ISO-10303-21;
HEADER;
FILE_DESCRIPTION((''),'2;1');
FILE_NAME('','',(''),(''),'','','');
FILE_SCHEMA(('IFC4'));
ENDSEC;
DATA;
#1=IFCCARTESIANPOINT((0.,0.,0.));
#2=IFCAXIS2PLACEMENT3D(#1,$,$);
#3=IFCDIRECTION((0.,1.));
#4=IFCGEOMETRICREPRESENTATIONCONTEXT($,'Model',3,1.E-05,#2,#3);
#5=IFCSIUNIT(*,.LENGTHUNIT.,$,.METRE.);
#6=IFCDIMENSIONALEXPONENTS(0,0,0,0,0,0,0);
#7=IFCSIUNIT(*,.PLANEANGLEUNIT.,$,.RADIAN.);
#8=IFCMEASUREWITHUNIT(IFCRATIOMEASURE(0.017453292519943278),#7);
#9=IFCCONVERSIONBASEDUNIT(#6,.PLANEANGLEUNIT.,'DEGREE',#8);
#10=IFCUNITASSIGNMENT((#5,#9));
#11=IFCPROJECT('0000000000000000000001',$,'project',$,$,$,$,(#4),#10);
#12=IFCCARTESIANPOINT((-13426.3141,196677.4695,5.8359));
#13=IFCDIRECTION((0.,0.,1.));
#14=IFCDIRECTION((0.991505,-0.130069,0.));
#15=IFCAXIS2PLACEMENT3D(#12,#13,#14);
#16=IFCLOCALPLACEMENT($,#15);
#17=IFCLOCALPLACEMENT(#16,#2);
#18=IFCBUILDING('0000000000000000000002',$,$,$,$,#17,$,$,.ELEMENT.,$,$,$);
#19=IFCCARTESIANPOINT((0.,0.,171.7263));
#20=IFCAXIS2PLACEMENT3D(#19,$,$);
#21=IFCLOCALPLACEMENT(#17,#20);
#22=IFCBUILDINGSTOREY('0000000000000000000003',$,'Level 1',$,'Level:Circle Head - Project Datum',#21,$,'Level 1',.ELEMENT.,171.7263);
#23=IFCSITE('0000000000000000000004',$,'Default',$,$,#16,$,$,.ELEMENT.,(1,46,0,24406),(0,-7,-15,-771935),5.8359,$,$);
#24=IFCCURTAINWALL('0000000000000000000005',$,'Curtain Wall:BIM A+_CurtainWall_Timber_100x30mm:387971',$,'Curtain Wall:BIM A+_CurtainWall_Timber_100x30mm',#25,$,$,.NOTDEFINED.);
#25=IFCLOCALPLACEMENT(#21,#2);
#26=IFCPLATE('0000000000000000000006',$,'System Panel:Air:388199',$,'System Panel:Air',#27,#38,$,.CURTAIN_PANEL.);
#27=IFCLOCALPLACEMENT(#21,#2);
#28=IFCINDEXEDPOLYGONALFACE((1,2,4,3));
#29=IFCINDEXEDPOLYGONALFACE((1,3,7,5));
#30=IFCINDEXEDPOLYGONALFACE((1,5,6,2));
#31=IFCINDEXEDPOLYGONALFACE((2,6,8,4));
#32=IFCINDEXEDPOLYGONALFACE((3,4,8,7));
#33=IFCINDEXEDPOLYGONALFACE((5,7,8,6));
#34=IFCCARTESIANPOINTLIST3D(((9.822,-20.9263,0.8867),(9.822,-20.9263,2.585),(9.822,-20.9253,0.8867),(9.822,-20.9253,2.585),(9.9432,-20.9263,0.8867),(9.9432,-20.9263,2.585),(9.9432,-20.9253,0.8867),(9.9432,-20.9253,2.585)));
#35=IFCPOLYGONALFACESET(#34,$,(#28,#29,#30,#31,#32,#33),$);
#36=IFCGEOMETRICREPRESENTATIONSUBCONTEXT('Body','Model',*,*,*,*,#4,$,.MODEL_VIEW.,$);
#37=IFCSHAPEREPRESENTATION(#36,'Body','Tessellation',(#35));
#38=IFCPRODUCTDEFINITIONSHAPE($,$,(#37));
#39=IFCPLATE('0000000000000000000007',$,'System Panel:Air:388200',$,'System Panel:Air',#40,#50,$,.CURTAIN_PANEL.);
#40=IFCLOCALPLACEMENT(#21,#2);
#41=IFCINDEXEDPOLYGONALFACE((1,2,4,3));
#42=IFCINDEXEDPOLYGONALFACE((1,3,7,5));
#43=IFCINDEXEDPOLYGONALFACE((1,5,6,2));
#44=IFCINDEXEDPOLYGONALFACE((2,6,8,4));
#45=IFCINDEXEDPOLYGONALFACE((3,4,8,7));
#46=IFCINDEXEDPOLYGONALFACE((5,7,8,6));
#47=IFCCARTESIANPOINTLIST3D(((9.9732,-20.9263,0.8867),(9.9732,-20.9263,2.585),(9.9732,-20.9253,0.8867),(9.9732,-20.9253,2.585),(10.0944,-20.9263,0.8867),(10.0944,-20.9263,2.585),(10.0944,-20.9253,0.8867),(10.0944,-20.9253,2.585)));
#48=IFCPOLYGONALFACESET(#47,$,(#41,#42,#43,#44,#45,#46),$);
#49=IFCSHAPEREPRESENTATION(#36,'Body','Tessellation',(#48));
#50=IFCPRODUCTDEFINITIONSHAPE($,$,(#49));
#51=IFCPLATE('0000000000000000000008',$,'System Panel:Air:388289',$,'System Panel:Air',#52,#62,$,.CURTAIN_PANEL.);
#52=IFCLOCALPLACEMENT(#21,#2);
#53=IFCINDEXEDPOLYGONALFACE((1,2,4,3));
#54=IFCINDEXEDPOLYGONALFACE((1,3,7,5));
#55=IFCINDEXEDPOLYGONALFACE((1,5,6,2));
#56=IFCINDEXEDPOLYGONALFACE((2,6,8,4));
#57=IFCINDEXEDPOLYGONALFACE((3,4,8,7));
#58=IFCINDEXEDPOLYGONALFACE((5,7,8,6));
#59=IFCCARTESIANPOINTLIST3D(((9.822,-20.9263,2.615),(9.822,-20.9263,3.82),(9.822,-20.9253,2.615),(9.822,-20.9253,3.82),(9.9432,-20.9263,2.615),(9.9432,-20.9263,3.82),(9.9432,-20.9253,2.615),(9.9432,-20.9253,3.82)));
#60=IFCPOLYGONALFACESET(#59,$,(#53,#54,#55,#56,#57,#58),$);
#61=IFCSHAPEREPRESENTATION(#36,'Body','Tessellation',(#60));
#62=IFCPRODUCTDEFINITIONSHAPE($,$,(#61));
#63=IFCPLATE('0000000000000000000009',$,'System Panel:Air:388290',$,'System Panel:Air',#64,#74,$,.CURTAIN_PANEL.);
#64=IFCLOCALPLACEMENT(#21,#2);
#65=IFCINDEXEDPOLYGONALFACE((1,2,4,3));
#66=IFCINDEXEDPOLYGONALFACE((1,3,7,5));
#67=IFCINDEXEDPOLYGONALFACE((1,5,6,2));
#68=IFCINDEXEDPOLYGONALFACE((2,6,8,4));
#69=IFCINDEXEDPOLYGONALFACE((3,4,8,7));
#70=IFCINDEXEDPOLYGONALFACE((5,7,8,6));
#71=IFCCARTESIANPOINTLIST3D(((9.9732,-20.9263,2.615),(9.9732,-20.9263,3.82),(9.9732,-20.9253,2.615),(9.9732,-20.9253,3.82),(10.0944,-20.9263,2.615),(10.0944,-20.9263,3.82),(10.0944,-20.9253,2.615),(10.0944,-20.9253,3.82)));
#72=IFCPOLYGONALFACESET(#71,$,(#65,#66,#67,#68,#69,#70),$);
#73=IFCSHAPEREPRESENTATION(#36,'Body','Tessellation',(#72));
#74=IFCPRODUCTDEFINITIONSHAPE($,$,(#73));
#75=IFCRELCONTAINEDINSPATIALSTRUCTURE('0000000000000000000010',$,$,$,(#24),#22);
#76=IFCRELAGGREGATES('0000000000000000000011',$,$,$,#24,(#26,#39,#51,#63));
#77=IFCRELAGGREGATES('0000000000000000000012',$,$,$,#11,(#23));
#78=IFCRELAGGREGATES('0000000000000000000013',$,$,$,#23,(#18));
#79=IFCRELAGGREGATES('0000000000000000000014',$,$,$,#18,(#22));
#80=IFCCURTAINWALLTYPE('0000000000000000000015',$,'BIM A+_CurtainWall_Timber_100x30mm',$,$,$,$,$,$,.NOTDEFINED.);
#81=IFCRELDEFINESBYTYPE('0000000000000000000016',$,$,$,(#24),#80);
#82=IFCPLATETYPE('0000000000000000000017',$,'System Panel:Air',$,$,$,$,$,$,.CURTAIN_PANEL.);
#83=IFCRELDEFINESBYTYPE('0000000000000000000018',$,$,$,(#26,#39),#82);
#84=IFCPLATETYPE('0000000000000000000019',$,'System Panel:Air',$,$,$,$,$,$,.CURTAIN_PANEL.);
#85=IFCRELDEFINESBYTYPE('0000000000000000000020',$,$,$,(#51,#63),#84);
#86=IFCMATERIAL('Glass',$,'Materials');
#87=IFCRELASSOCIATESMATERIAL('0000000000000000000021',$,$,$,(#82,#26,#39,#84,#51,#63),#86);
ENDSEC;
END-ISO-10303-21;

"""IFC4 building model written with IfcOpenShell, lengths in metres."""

from ifc_helpers import new_model, entity, si_unit, converted_unit, direction, frame, origin, place, context, subcontext, project, spatial, indexed_curve, outline, extrude, source, transform, mapped, material, type_object, type_shapes, element, aggregate, save


model = new_model("IFC4")

# Units and contexts
model_context = context("Model", 3, precision=1e-05, world=origin(), true_north=direction((0.0, 1.0)))
body_context = subcontext(model_context, "Body", "Model", "MODEL_VIEW")
ifc_project = project(units=[si_unit("LENGTHUNIT", "METRE"), converted_unit("PLANEANGLEUNIT", "DEGREE", entity("IfcRatioMeasure", 0.017453292519943278), si_unit("PLANEANGLEUNIT", "RADIAN"), dimensions=[0, 0, 0, 0, 0, 0, 0])], contexts=[model_context])

# Site, building, storey
site_placement = place(None, frame((-13426.3141, 196677.4695, 5.8359), z_axis=(0.0, 0.0, 1.0), x_axis=(0.991505, -0.130069, 0.0)))
site = spatial("IfcSite", under=ifc_project, at=site_placement, Name="Default", CompositionType="ELEMENT", RefLatitude=(1, 46, 0, 24406), RefLongitude=(0, -7, -15, -771935), RefElevation=5.8359)
building_placement = place(site_placement, origin())
building = spatial("IfcBuilding", under=site, at=building_placement, CompositionType="ELEMENT")
storey_placement = place(building_placement, frame((0.0, 0.0, 171.7263)))
storey = spatial("IfcBuildingStorey", under=building, at=storey_placement, Name="Level 1", ObjectType="Level:Circle Head - Project Datum", LongName="Level 1", CompositionType="ELEMENT", Elevation=171.7263)

# Curtain wall
curtain_wall_type_1 = type_object("IfcCurtainWallType", Name="BIM A+_CurtainWall_Timber_100x30mm", PredefinedType="NOTDEFINED")
curtain_wall_1_placement = place(storey_placement, frame((0.0, 0.0, -171.7263)))
curtain_wall_1 = element("IfcCurtainWall", 1, at=curtain_wall_1_placement, inside=storey, type_object=curtain_wall_type_1, Name="Curtain Wall:BIM A+_CurtainWall_Timber_100x30mm:387971", ObjectType="Curtain Wall:BIM A+_CurtainWall_Timber_100x30mm", PredefinedType="NOTDEFINED")

# Plates
ifc_material_1 = material(Name="Glass", Category="Materials")
plate_type_1 = type_object("IfcPlateType", Name="System Panel:Air", PredefinedType="CURTAIN_PANEL", material=ifc_material_1)
shared_shape_1 = source(origin(), body_context, "Body", "SweptSolid", [
    extrude(outline(indexed_curve([(-0.0005, -0.0606), (0.0005, -0.0606), (0.0005, 0.0606), (-0.0005, 0.0606), (-0.0005, -0.0606)], self_intersect=False)), frame((0.0, 0.0, 0.0), z_axis=(0.0, 0.0, 1.0), x_axis=(0.0, 1.0, 0.0)), (0.0, 0.0, 1.0), 1.6983),
])
type_shapes(plate_type_1, [shared_shape_1])
plate_1_placement = place(curtain_wall_1_placement, frame((9.8826, -20.9258, 172.613)))
plate_1 = element("IfcPlate", 2, at=plate_1_placement, type_object=plate_type_1, material=ifc_material_1, Name="System Panel:Air:388199", ObjectType="System Panel:Air", PredefinedType="CURTAIN_PANEL", context=body_context, shape_type="MappedRepresentation", body=[
    mapped(shared_shape_1, transform((0.0, 0.0, 0.0), scale=1.0)),
])
plate_2_placement = place(curtain_wall_1_placement, frame((10.0338, -20.9258, 172.613)))
plate_2 = element("IfcPlate", 3, at=plate_2_placement, type_object=plate_type_1, material=ifc_material_1, Name="System Panel:Air:388200", ObjectType="System Panel:Air", PredefinedType="CURTAIN_PANEL", context=body_context, shape_type="MappedRepresentation", body=[
    mapped(shared_shape_1, transform((0.0, 0.0, 0.0), scale=1.0)),
])
plate_type_2 = type_object("IfcPlateType", Name="System Panel:Air", PredefinedType="CURTAIN_PANEL", material=ifc_material_1)
shared_shape_2 = source(origin(), body_context, "Body", "SweptSolid", [
    extrude(outline(indexed_curve([(-0.0005, -0.0606), (0.0005, -0.0606), (0.0005, 0.0606), (-0.0005, 0.0606), (-0.0005, -0.0606)], self_intersect=False)), frame((0.0, 0.0, 0.0), z_axis=(0.0, 0.0, 1.0), x_axis=(0.0, 1.0, 0.0)), (0.0, 0.0, 1.0), 1.205),
])
type_shapes(plate_type_2, [shared_shape_2])
plate_3_placement = place(curtain_wall_1_placement, frame((9.8826, -20.9258, 174.3413)))
plate_3 = element("IfcPlate", 4, at=plate_3_placement, type_object=plate_type_2, material=ifc_material_1, Name="System Panel:Air:388289", ObjectType="System Panel:Air", PredefinedType="CURTAIN_PANEL", context=body_context, shape_type="MappedRepresentation", body=[
    mapped(shared_shape_2, transform((0.0, 0.0, 0.0), scale=1.0)),
])
plate_4_placement = place(curtain_wall_1_placement, frame((10.0338, -20.9258, 174.3413)))
plate_4 = element("IfcPlate", 5, at=plate_4_placement, type_object=plate_type_2, material=ifc_material_1, Name="System Panel:Air:388290", ObjectType="System Panel:Air", PredefinedType="CURTAIN_PANEL", context=body_context, shape_type="MappedRepresentation", body=[
    mapped(shared_shape_2, transform((0.0, 0.0, 0.0), scale=1.0)),
])
aggregate(curtain_wall_1, [plate_1, plate_2, plate_3, plate_4])

save(model, "model.ifc")
